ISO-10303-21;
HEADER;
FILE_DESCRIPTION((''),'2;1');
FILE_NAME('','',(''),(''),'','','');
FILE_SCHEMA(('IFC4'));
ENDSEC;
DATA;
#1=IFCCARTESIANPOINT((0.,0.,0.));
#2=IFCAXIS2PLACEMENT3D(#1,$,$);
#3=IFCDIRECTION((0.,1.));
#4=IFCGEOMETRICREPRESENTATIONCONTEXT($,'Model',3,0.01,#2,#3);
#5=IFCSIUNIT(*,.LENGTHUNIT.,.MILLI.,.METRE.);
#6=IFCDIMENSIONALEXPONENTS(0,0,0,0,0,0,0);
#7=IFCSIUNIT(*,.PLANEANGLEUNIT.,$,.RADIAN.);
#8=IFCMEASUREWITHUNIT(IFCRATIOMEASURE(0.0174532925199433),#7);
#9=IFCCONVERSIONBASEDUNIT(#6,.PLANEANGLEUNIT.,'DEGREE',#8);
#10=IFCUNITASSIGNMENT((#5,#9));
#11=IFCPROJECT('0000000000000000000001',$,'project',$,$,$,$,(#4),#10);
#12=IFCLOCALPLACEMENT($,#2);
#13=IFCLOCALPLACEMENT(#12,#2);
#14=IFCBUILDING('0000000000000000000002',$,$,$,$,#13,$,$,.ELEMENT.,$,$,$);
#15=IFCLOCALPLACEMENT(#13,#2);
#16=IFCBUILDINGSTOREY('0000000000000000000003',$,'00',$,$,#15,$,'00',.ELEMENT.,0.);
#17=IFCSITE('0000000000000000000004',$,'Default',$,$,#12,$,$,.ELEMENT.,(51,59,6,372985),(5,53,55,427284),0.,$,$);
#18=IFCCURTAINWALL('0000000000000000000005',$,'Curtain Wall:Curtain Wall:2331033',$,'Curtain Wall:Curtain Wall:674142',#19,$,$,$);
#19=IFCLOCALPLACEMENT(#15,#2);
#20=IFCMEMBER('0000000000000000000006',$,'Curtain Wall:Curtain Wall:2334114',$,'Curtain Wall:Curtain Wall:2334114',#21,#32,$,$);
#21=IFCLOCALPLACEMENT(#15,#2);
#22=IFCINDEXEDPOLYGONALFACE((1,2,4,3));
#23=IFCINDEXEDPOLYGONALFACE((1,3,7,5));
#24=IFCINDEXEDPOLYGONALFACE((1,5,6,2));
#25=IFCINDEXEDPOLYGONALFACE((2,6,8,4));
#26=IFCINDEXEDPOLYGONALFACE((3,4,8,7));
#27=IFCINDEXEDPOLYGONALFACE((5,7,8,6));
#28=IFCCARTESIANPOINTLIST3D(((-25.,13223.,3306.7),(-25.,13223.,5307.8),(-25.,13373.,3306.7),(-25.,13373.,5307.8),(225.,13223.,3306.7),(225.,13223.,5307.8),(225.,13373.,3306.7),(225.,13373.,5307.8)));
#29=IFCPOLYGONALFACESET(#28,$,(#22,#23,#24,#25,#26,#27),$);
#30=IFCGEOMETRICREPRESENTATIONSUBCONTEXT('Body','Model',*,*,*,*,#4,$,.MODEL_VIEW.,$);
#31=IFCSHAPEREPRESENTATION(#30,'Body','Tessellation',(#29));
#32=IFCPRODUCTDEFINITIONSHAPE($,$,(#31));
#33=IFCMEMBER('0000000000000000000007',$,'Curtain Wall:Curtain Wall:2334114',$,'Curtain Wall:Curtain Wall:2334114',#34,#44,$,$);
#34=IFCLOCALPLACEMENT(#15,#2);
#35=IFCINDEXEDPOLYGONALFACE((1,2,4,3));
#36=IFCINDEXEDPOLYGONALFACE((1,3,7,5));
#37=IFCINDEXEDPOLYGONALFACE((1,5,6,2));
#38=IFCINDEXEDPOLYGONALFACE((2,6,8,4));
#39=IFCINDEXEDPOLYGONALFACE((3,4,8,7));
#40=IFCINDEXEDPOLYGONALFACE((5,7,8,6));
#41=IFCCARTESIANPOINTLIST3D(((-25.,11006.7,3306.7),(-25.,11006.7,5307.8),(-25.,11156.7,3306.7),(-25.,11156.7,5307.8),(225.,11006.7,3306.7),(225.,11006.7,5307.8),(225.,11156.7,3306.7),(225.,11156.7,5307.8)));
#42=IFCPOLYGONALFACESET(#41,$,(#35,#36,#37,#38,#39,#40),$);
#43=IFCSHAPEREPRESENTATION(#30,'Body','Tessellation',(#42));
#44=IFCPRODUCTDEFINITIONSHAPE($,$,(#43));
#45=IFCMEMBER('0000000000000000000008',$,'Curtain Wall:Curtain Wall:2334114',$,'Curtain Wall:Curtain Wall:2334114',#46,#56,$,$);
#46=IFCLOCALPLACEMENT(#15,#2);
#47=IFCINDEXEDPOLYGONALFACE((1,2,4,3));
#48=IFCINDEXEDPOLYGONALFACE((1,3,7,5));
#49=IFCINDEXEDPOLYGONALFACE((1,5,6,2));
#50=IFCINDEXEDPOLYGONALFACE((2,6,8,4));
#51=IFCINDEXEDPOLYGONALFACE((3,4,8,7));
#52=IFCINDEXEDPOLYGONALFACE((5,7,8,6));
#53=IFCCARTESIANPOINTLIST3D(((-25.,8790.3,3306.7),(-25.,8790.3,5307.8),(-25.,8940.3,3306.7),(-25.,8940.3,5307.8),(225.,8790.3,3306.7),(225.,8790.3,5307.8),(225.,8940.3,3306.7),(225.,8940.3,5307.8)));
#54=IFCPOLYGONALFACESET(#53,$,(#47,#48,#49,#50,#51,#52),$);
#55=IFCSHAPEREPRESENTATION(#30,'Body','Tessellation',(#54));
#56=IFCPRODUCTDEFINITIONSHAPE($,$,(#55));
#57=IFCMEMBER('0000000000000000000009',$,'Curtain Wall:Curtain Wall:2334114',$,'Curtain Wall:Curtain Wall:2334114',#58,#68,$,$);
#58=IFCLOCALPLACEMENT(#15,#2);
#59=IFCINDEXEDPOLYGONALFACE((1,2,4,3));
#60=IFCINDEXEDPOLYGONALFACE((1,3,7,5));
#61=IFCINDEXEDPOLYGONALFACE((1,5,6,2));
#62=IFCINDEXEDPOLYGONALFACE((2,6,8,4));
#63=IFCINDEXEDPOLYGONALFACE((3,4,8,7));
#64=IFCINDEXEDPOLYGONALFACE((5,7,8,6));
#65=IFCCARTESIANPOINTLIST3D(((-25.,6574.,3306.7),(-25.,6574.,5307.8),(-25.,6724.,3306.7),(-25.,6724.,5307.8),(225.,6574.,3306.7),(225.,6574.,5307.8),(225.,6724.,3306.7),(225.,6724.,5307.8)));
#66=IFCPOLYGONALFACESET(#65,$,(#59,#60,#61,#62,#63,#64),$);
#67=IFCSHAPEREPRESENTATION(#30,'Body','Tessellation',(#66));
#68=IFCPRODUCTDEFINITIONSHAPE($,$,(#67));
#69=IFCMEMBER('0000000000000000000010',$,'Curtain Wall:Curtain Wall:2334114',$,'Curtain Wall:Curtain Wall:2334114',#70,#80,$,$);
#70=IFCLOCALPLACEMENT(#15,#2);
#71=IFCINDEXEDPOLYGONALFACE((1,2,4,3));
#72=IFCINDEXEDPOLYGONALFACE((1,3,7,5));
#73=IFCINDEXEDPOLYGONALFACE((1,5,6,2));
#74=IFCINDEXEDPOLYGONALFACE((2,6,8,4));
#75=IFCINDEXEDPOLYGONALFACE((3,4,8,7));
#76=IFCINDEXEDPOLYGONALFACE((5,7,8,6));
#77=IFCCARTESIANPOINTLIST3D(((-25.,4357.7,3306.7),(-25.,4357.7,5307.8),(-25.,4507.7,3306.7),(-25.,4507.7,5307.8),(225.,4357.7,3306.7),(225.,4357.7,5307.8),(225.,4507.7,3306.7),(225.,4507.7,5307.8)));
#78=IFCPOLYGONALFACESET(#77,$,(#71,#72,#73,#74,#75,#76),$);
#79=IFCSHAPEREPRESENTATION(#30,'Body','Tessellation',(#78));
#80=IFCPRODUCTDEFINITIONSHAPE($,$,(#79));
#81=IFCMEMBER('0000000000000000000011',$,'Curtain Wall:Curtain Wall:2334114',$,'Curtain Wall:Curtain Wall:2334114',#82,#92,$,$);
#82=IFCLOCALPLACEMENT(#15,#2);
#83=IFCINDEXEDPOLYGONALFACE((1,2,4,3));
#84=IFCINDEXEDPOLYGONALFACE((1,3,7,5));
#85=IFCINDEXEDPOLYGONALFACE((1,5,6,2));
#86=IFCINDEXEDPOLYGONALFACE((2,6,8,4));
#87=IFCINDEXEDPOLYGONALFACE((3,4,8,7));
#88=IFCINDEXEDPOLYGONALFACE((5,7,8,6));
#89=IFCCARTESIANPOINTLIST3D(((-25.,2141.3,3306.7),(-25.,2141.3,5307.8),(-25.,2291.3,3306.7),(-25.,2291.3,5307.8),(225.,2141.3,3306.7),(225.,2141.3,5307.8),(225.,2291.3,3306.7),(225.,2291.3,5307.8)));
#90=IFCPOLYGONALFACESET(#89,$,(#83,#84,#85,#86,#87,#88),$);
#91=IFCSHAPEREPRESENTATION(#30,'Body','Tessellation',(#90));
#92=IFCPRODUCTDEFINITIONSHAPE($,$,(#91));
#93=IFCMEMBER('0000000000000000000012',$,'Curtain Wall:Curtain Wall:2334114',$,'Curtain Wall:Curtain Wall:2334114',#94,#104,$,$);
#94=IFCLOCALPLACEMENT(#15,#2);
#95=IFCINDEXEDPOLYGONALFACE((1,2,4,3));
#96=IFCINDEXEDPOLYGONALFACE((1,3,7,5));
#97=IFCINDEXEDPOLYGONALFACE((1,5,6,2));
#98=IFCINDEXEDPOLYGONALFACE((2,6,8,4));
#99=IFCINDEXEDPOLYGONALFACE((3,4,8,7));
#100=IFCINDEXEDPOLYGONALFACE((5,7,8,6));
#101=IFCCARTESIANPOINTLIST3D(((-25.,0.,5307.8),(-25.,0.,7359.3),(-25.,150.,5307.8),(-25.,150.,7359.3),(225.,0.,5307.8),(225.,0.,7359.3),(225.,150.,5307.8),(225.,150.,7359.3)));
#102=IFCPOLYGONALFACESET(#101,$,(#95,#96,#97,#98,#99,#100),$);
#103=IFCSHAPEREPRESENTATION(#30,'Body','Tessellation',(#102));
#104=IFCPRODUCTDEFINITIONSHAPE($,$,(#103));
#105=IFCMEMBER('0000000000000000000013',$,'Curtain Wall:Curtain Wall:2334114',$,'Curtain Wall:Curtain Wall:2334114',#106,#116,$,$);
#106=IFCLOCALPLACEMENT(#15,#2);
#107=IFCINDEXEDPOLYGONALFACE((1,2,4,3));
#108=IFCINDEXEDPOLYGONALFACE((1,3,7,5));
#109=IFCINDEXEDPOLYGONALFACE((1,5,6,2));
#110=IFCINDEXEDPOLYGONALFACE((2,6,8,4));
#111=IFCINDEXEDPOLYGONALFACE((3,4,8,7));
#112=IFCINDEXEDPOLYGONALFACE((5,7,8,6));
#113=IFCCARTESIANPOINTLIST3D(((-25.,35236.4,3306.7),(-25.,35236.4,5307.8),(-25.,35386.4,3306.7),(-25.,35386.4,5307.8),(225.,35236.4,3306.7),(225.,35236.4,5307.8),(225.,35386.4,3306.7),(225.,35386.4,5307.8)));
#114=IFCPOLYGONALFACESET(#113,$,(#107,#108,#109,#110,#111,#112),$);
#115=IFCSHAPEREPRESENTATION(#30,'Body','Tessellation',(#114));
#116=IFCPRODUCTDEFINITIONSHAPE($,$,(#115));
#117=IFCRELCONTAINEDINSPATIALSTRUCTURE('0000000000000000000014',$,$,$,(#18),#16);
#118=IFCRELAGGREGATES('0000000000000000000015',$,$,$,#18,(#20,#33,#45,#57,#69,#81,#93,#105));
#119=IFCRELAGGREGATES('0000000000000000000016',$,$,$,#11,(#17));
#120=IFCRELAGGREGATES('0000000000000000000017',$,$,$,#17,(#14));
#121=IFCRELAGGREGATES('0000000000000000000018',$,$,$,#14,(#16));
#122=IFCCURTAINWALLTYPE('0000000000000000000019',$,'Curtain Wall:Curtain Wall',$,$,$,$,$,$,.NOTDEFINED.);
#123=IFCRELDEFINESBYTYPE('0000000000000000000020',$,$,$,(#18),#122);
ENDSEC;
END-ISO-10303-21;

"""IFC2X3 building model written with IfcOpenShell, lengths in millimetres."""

from ifc_helpers import new_model, entity, si_unit, converted_unit, direction, frame, frame_2d, origin, origin_2d_with_axis, place, context, subcontext, project, spatial, rectangle, extrude, type_object, element, aggregate, save


model = new_model("IFC2X3")

# Units and contexts
model_context = context("Model", 3, precision=0.01, world=origin(), true_north=direction((0.0, 1.0)))
body_context = subcontext(model_context, "Body", "Model", "MODEL_VIEW")
ifc_project = project(units=[si_unit("LENGTHUNIT", "METRE", prefix="MILLI"), converted_unit("PLANEANGLEUNIT", "DEGREE", entity("IfcRatioMeasure", 0.0174532925199433), si_unit("PLANEANGLEUNIT", "RADIAN"), dimensions=[0, 0, 0, 0, 0, 0, 0])], contexts=[model_context])

# Site, building, storey
site_placement = place(None, origin())
site = spatial("IfcSite", under=ifc_project, at=site_placement, Name="Default", CompositionType="ELEMENT", RefLatitude=(51, 59, 6, 372985), RefLongitude=(5, 53, 55, 427284), RefElevation=0.0)
building_placement = place(site_placement, origin())
building = spatial("IfcBuilding", under=site, at=building_placement, CompositionType="ELEMENT")
storey_placement = place(building_placement, origin())
storey = spatial("IfcBuildingStorey", under=building, at=storey_placement, Name="00", LongName="00", CompositionType="ELEMENT", Elevation=0.0)

# Curtain wall, members
curtain_wall_type = type_object("IfcCurtainWallType", Name="Curtain Wall:Curtain Wall", PredefinedType="NOTDEFINED")
curtain_wall_placement = place(storey_placement, origin())
curtain_wall = element("IfcCurtainWall", 1, at=curtain_wall_placement, inside=storey, type_object=curtain_wall_type, Name="Curtain Wall:Curtain Wall:2331033", ObjectType="Curtain Wall:Curtain Wall:674142")
member_1_placement = place(curtain_wall_placement, origin())
member_1 = element("IfcMember", 2, at=member_1_placement, Name="Curtain Wall:Curtain Wall:2334114", ObjectType="Curtain Wall:Curtain Wall:2334114", context=body_context, shape_type="SweptSolid", body=[
    extrude(rectangle(XDim=250.0, YDim=150.0, at=origin_2d_with_axis()), frame((100.0, 13298.0, 3306.7), z_axis=(0.0, 0.0, 1.0), x_axis=(-1.0, 0.0, 0.0)), (0.0, 0.0, 1.0), 2001.1),
])
member_2_placement = place(curtain_wall_placement, origin())
member_2 = element("IfcMember", 3, at=member_2_placement, Name="Curtain Wall:Curtain Wall:2334114", ObjectType="Curtain Wall:Curtain Wall:2334114", context=body_context, shape_type="SweptSolid", body=[
    extrude(rectangle(XDim=250.0, YDim=150.0, at=origin_2d_with_axis()), frame((100.0, 11081.7, 3306.7), z_axis=(0.0, 0.0, 1.0), x_axis=(-1.0, 0.0, 0.0)), (0.0, 0.0, 1.0), 2001.1),
])
member_3_placement = place(curtain_wall_placement, origin())
member_3 = element("IfcMember", 4, at=member_3_placement, Name="Curtain Wall:Curtain Wall:2334114", ObjectType="Curtain Wall:Curtain Wall:2334114", context=body_context, shape_type="SweptSolid", body=[
    extrude(rectangle(XDim=250.0, YDim=150.0, at=frame_2d((0.0, 0.0), x_axis=(1.0, 0.0))), frame((100.0, 8865.3, 3306.7), z_axis=(0.0, 0.0, 1.0), x_axis=(-1.0, 0.0, 0.0)), (0.0, 0.0, 1.0), 2001.1),
])
member_4_placement = place(curtain_wall_placement, origin())
member_4 = element("IfcMember", 5, at=member_4_placement, Name="Curtain Wall:Curtain Wall:2334114", ObjectType="Curtain Wall:Curtain Wall:2334114", context=body_context, shape_type="SweptSolid", body=[
    extrude(rectangle(XDim=250.0, YDim=150.0, at=frame_2d((0.0, 0.0), x_axis=(1.0, 0.0))), frame((100.0, 6649.0, 3306.7), z_axis=(0.0, 0.0, 1.0), x_axis=(-1.0, 0.0, 0.0)), (0.0, 0.0, 1.0), 2001.1),
])
member_5_placement = place(curtain_wall_placement, origin())
member_5 = element("IfcMember", 6, at=member_5_placement, Name="Curtain Wall:Curtain Wall:2334114", ObjectType="Curtain Wall:Curtain Wall:2334114", context=body_context, shape_type="SweptSolid", body=[
    extrude(rectangle(XDim=250.0, YDim=150.0, at=frame_2d((0.0, 0.0), x_axis=(1.0, 0.0))), frame((100.0, 4432.7, 3306.7), z_axis=(0.0, 0.0, 1.0), x_axis=(-1.0, 0.0, 0.0)), (0.0, 0.0, 1.0), 2001.1),
])
member_6_placement = place(curtain_wall_placement, origin())
member_6 = element("IfcMember", 7, at=member_6_placement, Name="Curtain Wall:Curtain Wall:2334114", ObjectType="Curtain Wall:Curtain Wall:2334114", context=body_context, shape_type="SweptSolid", body=[
    extrude(rectangle(XDim=250.0, YDim=150.0, at=frame_2d((0.0, 0.0), x_axis=(1.0, 0.0))), frame((100.0, 2216.3, 3306.7), z_axis=(0.0, 0.0, 1.0), x_axis=(-1.0, 0.0, 0.0)), (0.0, 0.0, 1.0), 2001.1),
])
member_7_placement = place(curtain_wall_placement, origin())
member_7 = element("IfcMember", 8, at=member_7_placement, Name="Curtain Wall:Curtain Wall:2334114", ObjectType="Curtain Wall:Curtain Wall:2334114", context=body_context, shape_type="SweptSolid", body=[
    extrude(rectangle(XDim=250.0, YDim=150.0, at=frame_2d((0.0, 0.0), x_axis=(1.0, 0.0))), frame((100.0, 75.0, 5307.8), z_axis=(0.0, 0.0, 1.0), x_axis=(-1.0, 0.0, 0.0)), (0.0, 0.0, 1.0), 2051.5),
])
member_8_placement = place(curtain_wall_placement, origin())
member_8 = element("IfcMember", 9, at=member_8_placement, Name="Curtain Wall:Curtain Wall:2334114", ObjectType="Curtain Wall:Curtain Wall:2334114", context=body_context, shape_type="SweptSolid", body=[
    extrude(rectangle(XDim=250.0, YDim=150.0, at=origin_2d_with_axis()), frame((100.0, 35311.4, 5307.8), z_axis=(0.0, 0.0, -1.0), x_axis=(-1.0, 0.0, 0.0)), (0.0, 0.0, 1.0), 2001.1),
])
aggregate(curtain_wall, [member_1, member_2, member_3, member_4, member_5, member_6, member_7, member_8])

save(model, "model.ifc")
